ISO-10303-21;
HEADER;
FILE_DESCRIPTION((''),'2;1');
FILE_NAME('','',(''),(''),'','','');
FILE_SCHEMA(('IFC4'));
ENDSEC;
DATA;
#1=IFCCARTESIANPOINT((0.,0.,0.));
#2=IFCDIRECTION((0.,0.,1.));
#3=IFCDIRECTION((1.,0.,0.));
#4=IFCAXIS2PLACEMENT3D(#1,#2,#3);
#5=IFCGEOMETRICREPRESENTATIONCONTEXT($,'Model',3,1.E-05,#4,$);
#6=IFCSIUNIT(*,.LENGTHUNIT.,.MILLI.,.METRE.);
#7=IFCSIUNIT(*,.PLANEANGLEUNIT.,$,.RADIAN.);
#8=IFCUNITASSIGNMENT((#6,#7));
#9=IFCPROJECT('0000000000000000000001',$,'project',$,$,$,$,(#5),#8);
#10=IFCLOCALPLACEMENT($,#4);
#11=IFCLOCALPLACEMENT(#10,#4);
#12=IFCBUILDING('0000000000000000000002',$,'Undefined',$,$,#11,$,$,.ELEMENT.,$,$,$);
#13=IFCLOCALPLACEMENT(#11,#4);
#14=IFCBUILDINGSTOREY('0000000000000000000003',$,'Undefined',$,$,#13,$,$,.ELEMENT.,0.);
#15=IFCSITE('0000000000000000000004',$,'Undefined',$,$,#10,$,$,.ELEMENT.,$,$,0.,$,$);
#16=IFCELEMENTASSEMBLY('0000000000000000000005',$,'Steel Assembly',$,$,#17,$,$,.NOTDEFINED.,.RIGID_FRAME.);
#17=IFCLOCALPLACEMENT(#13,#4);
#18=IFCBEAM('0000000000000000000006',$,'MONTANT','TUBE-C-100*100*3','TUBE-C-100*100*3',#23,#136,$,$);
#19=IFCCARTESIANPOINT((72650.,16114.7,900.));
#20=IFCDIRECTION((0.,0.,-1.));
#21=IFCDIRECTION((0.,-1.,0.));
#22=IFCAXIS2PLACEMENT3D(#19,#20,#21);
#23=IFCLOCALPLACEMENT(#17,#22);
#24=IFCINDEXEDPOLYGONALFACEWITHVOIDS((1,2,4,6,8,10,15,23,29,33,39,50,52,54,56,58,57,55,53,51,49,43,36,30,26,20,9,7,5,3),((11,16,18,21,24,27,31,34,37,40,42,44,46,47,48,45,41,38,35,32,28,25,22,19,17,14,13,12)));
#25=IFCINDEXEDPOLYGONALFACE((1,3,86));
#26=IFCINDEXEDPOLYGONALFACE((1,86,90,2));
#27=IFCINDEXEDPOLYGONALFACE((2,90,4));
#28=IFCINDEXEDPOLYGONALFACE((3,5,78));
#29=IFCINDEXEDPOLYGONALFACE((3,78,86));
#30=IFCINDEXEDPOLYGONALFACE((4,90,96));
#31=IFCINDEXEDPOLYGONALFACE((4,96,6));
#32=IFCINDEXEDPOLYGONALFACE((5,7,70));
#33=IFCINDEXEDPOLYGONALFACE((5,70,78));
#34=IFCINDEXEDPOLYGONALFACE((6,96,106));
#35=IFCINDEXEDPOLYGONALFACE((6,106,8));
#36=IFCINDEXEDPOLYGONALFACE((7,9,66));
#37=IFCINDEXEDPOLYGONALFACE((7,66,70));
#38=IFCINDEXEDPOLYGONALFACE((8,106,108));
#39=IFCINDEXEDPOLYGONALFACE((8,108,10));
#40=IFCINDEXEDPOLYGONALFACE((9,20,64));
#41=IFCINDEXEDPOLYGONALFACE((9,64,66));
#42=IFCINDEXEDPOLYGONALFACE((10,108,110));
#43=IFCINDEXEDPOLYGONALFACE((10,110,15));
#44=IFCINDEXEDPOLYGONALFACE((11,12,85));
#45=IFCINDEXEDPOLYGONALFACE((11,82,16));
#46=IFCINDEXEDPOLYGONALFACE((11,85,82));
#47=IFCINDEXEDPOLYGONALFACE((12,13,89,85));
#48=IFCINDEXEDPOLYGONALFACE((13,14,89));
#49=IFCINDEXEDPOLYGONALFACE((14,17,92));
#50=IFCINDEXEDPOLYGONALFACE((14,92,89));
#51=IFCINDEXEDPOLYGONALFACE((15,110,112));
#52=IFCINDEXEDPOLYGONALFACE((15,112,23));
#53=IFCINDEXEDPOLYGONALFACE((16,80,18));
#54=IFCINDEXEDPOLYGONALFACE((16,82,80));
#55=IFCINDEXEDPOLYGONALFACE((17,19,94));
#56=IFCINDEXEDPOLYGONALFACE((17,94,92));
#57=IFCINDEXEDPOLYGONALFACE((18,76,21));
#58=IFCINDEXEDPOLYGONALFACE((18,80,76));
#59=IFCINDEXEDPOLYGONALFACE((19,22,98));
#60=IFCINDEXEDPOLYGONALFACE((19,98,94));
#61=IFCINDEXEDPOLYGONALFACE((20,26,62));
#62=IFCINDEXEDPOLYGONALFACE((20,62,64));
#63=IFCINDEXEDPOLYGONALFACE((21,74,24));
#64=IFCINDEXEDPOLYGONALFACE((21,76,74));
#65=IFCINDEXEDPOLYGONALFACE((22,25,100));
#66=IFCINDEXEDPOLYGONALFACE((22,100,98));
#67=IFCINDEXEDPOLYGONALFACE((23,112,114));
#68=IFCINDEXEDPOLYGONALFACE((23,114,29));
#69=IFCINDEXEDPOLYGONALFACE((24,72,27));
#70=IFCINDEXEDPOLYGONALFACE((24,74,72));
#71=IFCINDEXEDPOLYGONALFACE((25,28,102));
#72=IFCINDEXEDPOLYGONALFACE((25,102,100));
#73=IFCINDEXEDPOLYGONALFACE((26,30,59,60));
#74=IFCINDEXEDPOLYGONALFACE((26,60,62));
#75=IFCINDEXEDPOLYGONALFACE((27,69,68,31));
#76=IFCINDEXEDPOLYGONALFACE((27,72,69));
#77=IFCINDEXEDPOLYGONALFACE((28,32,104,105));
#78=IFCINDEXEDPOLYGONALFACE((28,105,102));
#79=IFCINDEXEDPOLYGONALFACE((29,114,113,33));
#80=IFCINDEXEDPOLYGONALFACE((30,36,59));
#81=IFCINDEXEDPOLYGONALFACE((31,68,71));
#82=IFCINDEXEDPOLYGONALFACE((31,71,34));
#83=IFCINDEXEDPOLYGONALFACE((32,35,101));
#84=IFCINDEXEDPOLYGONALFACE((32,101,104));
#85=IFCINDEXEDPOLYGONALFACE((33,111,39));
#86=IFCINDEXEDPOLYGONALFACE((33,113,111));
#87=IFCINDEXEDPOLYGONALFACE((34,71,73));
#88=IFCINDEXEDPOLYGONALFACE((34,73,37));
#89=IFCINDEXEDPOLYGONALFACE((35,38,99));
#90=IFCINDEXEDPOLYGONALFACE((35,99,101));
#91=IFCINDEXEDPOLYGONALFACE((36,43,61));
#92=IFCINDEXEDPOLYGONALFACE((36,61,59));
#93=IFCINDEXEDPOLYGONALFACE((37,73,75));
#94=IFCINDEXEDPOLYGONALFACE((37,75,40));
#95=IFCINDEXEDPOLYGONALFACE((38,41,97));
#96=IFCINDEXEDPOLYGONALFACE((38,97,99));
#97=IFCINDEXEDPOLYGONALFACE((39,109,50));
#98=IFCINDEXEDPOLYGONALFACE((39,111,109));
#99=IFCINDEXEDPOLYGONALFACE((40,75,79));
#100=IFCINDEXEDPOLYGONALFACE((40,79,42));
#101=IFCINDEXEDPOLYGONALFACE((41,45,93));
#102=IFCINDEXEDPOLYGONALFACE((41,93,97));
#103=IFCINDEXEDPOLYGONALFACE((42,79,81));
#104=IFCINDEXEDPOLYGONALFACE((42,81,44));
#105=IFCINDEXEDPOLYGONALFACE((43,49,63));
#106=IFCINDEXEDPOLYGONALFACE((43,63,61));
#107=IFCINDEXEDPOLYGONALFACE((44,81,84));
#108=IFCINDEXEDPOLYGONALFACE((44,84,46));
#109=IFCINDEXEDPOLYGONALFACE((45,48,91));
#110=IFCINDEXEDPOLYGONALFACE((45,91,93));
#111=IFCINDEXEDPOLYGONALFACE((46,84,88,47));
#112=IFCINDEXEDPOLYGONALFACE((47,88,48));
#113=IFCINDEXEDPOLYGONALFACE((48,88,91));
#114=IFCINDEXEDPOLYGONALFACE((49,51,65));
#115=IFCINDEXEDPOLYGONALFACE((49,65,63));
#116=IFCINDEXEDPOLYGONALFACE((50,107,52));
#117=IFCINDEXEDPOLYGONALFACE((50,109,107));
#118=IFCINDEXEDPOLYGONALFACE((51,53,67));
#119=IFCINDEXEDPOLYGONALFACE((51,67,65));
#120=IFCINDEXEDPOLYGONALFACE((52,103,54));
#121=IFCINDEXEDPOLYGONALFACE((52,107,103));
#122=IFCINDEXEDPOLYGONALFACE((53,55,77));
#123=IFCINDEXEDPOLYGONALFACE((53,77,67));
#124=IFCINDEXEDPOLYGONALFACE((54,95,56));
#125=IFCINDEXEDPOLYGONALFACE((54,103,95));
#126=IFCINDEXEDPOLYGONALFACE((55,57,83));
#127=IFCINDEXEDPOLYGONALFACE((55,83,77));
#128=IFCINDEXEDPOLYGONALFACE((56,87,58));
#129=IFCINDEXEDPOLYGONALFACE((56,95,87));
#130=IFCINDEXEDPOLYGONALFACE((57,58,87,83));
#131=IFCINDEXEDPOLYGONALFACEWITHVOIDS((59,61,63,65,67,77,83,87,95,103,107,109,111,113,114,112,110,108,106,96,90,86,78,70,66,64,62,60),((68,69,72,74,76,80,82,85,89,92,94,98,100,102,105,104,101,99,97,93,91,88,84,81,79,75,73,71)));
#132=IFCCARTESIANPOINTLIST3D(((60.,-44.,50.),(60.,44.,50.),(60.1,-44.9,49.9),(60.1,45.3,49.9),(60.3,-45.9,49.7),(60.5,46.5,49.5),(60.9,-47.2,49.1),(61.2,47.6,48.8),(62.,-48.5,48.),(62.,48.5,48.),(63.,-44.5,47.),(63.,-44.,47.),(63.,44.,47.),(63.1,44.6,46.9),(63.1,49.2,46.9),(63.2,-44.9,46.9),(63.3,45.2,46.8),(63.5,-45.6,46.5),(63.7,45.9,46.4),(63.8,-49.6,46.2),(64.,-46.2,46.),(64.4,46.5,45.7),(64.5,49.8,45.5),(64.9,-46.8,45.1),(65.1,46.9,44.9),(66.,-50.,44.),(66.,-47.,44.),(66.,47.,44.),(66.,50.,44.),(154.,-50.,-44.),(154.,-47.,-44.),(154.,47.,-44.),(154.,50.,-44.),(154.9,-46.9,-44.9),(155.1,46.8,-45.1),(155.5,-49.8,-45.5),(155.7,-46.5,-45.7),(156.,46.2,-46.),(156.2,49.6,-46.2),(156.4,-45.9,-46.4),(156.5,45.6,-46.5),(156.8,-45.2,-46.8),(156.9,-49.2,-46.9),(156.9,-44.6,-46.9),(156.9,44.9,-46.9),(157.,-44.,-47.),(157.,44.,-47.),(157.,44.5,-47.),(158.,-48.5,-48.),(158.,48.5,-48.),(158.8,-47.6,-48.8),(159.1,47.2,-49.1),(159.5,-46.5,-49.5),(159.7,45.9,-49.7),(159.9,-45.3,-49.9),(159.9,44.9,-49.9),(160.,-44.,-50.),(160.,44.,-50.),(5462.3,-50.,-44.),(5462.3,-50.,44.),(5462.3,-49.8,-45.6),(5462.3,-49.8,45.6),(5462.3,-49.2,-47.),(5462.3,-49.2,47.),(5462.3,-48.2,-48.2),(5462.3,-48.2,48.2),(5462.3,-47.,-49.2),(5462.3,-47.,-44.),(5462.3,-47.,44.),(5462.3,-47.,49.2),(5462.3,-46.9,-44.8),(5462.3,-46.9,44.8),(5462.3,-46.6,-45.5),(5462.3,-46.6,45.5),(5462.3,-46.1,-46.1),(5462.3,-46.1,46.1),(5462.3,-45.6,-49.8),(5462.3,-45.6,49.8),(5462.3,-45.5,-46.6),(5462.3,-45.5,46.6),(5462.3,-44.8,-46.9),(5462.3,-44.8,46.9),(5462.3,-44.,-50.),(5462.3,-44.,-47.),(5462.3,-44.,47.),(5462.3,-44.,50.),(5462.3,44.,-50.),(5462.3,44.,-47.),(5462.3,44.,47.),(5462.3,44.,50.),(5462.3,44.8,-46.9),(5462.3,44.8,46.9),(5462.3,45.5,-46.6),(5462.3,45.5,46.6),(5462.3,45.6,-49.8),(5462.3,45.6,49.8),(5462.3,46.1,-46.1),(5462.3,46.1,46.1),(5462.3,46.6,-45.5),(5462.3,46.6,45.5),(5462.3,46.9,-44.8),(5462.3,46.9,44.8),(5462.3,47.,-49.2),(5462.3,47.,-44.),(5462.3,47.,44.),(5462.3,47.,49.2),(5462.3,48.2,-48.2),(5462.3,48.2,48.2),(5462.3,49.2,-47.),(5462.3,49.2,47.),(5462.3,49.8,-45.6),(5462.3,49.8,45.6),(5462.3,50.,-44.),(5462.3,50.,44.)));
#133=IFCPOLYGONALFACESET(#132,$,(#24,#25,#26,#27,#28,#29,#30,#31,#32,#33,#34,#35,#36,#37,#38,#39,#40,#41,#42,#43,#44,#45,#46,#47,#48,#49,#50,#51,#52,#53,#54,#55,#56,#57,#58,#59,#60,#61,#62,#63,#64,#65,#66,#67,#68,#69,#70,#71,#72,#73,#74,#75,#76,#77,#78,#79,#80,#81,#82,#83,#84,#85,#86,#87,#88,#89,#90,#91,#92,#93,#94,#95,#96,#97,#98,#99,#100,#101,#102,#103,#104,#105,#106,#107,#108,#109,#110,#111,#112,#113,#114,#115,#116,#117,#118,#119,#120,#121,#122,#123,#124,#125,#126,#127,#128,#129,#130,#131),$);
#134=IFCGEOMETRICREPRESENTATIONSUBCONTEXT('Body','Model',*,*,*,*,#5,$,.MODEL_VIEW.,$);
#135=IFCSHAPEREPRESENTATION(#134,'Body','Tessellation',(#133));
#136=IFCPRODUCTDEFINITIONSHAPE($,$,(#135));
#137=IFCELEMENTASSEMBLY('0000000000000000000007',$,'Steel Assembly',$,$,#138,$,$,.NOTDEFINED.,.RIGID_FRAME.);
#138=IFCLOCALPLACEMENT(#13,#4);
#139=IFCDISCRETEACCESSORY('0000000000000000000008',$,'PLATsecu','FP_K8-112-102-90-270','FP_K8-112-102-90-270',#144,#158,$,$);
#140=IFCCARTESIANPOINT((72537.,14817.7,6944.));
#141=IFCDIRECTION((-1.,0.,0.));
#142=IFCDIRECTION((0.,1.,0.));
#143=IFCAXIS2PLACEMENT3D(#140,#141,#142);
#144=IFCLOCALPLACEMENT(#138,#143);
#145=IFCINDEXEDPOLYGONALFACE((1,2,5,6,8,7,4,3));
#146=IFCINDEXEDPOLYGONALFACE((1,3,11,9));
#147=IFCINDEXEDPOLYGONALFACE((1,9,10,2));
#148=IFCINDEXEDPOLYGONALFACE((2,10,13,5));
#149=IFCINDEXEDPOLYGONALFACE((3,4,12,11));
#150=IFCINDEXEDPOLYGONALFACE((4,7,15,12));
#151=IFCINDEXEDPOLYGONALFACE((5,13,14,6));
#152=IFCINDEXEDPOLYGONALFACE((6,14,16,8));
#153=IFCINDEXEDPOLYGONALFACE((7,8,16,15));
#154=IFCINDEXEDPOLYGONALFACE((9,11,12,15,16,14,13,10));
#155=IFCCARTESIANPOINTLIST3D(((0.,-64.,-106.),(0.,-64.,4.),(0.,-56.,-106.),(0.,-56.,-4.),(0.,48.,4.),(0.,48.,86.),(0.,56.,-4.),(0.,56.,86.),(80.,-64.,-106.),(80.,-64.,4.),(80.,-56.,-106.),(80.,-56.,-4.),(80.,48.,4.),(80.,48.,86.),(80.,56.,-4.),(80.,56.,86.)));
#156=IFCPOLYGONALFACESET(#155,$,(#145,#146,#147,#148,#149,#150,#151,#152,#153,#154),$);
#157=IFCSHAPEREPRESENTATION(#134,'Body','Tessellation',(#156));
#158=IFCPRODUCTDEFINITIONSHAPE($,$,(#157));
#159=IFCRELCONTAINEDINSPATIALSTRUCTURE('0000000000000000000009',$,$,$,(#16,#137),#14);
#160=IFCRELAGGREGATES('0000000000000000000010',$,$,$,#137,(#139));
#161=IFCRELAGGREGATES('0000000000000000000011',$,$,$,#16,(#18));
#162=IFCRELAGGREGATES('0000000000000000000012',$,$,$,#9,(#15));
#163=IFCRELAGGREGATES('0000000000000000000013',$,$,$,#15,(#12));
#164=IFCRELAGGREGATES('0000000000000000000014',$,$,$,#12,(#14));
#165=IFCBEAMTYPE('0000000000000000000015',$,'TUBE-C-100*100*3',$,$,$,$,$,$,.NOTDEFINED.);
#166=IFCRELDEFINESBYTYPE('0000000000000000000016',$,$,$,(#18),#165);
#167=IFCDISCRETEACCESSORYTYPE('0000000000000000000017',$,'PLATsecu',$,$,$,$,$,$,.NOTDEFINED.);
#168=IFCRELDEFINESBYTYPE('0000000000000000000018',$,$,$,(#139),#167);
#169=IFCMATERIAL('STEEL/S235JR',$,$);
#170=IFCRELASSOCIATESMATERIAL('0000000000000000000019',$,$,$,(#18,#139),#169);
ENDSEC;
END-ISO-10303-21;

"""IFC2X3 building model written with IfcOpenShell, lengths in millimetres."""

from ifc_helpers import new_model, si_unit, frame, origin_with_axes, origin_2d_with_axis, place, context, subcontext, project, spatial, polyline, hollow_rectangle, outline, extrude, clip, halfspace, material, type_object, element, aggregate, save


model = new_model("IFC2X3")

# Units and contexts
model_context = context("Model", 3, precision=1e-05, world=origin_with_axes())
body_context = subcontext(model_context, "Body", "Model", "MODEL_VIEW")
ifc_project = project(units=[si_unit("LENGTHUNIT", "METRE", prefix="MILLI"), si_unit("PLANEANGLEUNIT", "RADIAN")], contexts=[model_context])

# Site, building, storey
site_placement = place(None, origin_with_axes())
site = spatial("IfcSite", under=ifc_project, at=site_placement, Name="Undefined", CompositionType="ELEMENT", RefElevation=0.0)
building_placement = place(site_placement, origin_with_axes())
building = spatial("IfcBuilding", under=site, at=building_placement, Name="Undefined", CompositionType="ELEMENT")
storey_placement = place(building_placement, origin_with_axes())
storey = spatial("IfcBuildingStorey", under=building, at=storey_placement, Name="Undefined", CompositionType="ELEMENT", Elevation=0.0)

# Shared definitions
ifc_material_1 = material(Name="STEEL/S235JR")

# Element assembly, beam
beam_type_1 = type_object("IfcBeamType", Name="TUBE-C-100*100*3", PredefinedType="NOTDEFINED")
assembly_1_placement = place(storey_placement, origin_with_axes())
assembly_1 = element("IfcElementAssembly", 1, at=assembly_1_placement, inside=storey, Name="Steel Assembly", AssemblyPlace="NOTDEFINED", PredefinedType="RIGID_FRAME")
beam_1_placement = place(assembly_1_placement, frame((72650.0, 16114.7, 900.0), z_axis=(0.0, 0.0, -1.0), x_axis=(0.0, -1.0, 0.0)))
beam_1 = element("IfcBeam", 2, at=beam_1_placement, type_object=beam_type_1, material=ifc_material_1, Name="MONTANT", Description="TUBE-C-100*100*3", ObjectType="TUBE-C-100*100*3", context=body_context, shape_type="Clipping", body=[
    clip(extrude(hollow_rectangle(XDim=100.0, YDim=100.0, WallThickness=3.0, InnerFilletRadius=3.0, OuterFilletRadius=6.0, at=origin_2d_with_axis()), frame((5462.3, 0.0, 0.0), z_axis=(-1.0, 0.0, 0.0), x_axis=(0.0, -1.0, 0.0)), (0.0, 0.0, 1.0), 5462.3), halfspace(frame((60.0, -52.2, 50.0), z_axis=(-0.707107, 0.0, -0.707107), x_axis=(0.707107, 0.0, -0.707107)), False)),
])

# Element assembly, discrete accessory
assembly_2_placement = place(storey_placement, origin_with_axes())
assembly_2 = element("IfcElementAssembly", 3, at=assembly_2_placement, inside=storey, Name="Steel Assembly", AssemblyPlace="NOTDEFINED", PredefinedType="RIGID_FRAME")
discrete_accessory_type_1 = type_object("IfcDiscreteAccessoryType", Name="PLATsecu")
discrete_accessory_1_placement = place(assembly_2_placement, frame((72537.0, 14817.7, 6944.0), z_axis=(-1.0, 0.0, 0.0), x_axis=(0.0, 1.0, 0.0)))
discrete_accessory_1 = element("IfcDiscreteAccessory", 4, at=discrete_accessory_1_placement, type_object=discrete_accessory_type_1, material=ifc_material_1, Name="PLATsecu", Description="FP_K8-112-102-90-270", ObjectType="FP_K8-112-102-90-270", context=body_context, shape_type="SweptSolid", body=[
    extrude(outline(polyline([(-56.0, 86.0), (-48.0, 86.0), (-48.0, 4.0), (64.0, 4.0), (64.0, -106.0), (56.0, -106.0), (56.0, -4.0), (-56.0, -4.0), (-56.0, 86.0)])), frame((80.0, 0.0, 0.0), z_axis=(-1.0, 0.0, 0.0), x_axis=(0.0, -1.0, 0.0)), (0.0, 0.0, 1.0), 80.0),
])
aggregate(assembly_2, [discrete_accessory_1])

aggregate(assembly_1, [beam_1])

save(model, "model.ifc")
